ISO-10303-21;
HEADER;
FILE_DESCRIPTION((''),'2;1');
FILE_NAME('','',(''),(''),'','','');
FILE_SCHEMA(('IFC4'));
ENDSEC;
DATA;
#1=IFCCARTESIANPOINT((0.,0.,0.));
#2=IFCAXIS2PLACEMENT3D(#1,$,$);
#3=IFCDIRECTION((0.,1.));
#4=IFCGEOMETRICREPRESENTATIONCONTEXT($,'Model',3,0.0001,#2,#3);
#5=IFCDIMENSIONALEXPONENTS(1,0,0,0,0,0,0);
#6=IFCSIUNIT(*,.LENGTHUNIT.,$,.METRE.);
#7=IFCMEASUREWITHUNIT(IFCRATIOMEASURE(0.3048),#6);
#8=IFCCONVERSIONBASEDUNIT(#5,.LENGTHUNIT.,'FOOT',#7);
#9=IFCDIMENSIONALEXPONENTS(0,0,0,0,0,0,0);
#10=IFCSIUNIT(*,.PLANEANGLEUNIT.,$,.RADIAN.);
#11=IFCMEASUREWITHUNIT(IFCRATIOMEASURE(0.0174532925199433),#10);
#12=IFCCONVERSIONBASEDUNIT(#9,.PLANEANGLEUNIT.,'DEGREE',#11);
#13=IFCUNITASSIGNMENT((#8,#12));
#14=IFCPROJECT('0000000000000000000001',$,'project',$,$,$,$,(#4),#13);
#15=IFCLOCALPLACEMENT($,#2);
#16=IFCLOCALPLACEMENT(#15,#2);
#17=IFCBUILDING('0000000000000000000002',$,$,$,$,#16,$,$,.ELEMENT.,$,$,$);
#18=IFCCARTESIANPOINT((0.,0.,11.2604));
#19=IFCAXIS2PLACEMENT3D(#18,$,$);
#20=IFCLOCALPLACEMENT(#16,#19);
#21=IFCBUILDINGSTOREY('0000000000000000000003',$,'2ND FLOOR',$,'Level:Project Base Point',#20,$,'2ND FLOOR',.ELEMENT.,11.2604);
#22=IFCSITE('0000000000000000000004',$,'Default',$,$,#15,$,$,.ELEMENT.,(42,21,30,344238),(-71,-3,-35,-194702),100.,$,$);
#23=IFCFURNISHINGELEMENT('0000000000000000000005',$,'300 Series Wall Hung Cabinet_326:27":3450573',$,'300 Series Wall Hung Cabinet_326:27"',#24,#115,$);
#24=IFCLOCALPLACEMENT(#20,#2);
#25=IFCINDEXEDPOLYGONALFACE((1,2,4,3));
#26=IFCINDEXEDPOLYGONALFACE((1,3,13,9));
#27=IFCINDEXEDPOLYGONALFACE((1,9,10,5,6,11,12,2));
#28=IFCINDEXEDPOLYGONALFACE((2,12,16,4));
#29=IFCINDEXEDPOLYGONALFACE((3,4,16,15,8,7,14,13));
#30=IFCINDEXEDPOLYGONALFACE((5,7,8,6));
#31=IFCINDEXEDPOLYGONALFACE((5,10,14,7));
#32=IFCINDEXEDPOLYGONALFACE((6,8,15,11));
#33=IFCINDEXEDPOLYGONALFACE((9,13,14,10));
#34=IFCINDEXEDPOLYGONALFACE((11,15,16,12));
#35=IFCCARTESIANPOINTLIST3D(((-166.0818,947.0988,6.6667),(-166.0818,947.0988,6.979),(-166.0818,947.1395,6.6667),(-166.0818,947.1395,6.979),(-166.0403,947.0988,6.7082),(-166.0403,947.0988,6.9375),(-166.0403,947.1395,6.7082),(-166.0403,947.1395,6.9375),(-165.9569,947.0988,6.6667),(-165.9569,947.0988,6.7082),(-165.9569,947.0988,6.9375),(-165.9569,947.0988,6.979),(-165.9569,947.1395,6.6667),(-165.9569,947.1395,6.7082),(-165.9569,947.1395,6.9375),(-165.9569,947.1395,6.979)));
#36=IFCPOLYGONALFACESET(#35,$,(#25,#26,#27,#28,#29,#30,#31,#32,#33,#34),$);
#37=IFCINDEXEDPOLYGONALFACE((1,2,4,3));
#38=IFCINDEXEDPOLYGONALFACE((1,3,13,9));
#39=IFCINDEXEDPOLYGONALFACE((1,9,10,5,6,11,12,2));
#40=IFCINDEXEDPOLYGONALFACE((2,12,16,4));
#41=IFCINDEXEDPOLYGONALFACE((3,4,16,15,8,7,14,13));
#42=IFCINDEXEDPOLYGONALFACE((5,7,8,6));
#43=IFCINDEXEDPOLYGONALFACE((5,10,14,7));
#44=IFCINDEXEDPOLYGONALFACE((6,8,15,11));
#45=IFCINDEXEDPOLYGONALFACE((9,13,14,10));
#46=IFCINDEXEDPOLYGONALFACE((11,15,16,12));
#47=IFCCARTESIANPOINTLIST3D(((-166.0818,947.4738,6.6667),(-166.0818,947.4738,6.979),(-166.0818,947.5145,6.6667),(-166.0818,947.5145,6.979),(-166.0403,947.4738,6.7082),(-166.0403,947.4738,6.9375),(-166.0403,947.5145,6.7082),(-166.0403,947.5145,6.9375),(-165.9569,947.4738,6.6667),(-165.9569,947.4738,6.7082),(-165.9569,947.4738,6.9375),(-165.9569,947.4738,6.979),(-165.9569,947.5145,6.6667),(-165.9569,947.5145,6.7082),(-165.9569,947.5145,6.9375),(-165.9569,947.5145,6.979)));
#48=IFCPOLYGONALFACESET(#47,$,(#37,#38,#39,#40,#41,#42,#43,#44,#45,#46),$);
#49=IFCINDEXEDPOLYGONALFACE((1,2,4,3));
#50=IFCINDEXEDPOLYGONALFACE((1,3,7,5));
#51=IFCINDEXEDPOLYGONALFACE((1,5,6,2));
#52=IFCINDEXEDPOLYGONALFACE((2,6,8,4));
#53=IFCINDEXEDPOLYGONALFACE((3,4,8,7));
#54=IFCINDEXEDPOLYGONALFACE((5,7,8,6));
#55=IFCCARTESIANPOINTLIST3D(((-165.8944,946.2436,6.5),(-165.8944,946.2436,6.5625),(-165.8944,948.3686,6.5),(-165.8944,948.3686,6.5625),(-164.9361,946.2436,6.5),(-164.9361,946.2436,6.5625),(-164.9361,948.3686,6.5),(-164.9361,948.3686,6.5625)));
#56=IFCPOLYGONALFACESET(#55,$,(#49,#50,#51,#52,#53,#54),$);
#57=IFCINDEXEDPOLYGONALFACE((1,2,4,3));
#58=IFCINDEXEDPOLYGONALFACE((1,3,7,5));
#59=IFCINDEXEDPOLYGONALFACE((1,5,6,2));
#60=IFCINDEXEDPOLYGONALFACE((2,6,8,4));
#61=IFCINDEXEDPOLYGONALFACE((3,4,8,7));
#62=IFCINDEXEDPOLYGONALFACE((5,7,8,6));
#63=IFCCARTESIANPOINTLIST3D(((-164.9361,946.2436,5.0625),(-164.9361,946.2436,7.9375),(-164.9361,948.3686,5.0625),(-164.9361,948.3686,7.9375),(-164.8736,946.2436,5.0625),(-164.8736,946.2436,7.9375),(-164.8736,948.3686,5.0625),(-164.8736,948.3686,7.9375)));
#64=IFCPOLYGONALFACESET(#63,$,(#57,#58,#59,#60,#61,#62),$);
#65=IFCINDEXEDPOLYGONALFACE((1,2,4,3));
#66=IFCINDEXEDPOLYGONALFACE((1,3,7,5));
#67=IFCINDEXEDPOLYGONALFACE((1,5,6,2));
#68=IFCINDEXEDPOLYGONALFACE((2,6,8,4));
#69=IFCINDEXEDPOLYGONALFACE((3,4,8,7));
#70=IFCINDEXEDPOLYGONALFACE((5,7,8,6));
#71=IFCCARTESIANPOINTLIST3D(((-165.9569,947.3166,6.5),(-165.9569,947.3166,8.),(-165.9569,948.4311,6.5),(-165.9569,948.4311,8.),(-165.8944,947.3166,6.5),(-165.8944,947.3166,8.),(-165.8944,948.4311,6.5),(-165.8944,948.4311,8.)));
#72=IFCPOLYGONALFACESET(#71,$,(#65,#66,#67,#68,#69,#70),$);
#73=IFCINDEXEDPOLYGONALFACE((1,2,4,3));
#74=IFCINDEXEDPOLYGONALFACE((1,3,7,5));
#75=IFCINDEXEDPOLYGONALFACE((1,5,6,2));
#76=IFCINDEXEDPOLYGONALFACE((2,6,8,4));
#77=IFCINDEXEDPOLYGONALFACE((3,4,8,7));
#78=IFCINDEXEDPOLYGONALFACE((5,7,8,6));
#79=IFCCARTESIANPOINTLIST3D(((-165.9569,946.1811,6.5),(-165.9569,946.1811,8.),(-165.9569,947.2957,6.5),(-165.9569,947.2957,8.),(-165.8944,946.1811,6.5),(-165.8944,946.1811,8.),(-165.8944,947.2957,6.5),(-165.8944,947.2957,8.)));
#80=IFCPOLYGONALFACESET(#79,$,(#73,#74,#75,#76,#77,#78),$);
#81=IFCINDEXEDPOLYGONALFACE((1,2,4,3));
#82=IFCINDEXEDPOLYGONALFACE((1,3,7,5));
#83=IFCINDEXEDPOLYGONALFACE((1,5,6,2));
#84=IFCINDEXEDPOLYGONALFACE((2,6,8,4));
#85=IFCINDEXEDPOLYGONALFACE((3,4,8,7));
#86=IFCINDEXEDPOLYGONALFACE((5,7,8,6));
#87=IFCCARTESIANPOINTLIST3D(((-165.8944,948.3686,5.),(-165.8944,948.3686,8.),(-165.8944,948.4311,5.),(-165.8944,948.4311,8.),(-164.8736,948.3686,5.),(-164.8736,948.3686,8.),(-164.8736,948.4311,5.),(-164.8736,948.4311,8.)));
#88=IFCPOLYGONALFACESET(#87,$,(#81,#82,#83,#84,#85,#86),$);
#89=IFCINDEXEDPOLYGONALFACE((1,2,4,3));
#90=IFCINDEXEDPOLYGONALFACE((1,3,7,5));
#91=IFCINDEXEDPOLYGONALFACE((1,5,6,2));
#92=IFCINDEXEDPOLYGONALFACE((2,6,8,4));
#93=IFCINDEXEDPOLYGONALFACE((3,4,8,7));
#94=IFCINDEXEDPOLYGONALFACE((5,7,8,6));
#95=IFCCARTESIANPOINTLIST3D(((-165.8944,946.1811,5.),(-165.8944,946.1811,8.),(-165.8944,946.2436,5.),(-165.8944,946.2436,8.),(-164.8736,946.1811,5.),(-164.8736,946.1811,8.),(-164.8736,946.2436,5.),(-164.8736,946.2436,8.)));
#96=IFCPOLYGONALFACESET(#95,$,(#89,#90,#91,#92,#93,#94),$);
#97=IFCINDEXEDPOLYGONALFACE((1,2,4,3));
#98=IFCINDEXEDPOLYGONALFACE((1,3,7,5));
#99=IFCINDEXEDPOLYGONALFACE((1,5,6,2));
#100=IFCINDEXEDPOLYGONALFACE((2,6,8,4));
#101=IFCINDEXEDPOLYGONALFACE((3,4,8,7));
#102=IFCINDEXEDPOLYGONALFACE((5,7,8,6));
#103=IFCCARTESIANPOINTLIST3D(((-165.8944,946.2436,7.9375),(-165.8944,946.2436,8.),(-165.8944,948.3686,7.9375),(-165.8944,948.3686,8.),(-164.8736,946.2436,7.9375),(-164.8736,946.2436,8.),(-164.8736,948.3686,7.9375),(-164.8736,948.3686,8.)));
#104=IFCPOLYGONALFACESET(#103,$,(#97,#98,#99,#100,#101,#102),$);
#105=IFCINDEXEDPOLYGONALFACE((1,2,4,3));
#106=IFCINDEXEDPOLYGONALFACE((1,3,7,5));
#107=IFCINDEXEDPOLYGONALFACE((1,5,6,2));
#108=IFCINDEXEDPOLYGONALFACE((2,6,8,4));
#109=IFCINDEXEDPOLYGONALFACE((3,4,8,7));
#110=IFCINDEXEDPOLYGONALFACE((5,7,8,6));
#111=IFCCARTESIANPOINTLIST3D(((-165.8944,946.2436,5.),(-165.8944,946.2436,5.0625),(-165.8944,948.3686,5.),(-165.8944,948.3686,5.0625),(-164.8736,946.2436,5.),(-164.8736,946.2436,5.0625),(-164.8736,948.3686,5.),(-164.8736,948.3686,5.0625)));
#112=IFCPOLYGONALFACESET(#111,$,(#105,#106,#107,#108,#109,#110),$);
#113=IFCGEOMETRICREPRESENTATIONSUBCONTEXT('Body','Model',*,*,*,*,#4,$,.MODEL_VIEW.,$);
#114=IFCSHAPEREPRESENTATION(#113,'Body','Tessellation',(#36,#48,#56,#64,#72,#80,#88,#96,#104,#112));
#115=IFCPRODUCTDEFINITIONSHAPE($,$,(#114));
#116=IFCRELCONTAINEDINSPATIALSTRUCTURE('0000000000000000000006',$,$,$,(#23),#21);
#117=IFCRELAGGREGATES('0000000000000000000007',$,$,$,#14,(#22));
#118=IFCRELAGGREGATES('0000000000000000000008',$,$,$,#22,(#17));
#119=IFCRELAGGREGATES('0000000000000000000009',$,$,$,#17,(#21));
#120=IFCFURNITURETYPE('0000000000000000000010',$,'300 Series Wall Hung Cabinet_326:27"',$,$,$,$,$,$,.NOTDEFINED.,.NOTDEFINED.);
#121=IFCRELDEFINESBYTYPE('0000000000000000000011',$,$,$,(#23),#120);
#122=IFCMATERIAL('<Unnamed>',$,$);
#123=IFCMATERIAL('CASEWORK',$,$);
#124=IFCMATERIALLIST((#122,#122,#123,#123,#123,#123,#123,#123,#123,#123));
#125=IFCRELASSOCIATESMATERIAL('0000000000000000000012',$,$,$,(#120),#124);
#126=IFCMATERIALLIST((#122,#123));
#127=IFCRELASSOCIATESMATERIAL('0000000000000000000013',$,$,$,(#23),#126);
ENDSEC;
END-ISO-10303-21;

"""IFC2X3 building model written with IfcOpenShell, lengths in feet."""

from ifc_helpers import new_model, entity, si_unit, converted_unit, direction, frame, frame_2d, origin, origin_2d_with_axis, place, context, subcontext, project, spatial, polyline, rectangle, outline, extrude, source, transform, mapped, material, material_list, type_object, type_shapes, element, save


model = new_model("IFC2X3")

# Units and contexts
model_context = context("Model", 3, precision=0.0001, world=origin(), true_north=direction((0.0, 1.0)))
body_context = subcontext(model_context, "Body", "Model", "MODEL_VIEW")
ifc_project = project(units=[converted_unit("LENGTHUNIT", "FOOT", entity("IfcRatioMeasure", 0.3048), si_unit("LENGTHUNIT", "METRE"), dimensions=[1, 0, 0, 0, 0, 0, 0]), converted_unit("PLANEANGLEUNIT", "DEGREE", entity("IfcRatioMeasure", 0.0174532925199433), si_unit("PLANEANGLEUNIT", "RADIAN"), dimensions=[0, 0, 0, 0, 0, 0, 0])], contexts=[model_context])

# Site, building, storey
site_placement = place(None, origin())
site = spatial("IfcSite", under=ifc_project, at=site_placement, Name="Default", CompositionType="ELEMENT", RefLatitude=(42, 21, 30, 344238), RefLongitude=(-71, -3, -35, -194702), RefElevation=100.0)
building_placement = place(site_placement, origin())
building = spatial("IfcBuilding", under=site, at=building_placement, CompositionType="ELEMENT")
storey_placement = place(building_placement, frame((0.0, 0.0, 11.2604)))
storey = spatial("IfcBuildingStorey", under=building, at=storey_placement, Name="2ND FLOOR", ObjectType="Level:Project Base Point", LongName="2ND FLOOR", CompositionType="ELEMENT", Elevation=11.2604)

# Furnishing element
ifc_material_1 = material(Name="<Unnamed>")
ifc_material_2 = material(Name="CASEWORK")
ifc_material_list_1 = material_list([ifc_material_1, ifc_material_2])
ifc_material_list_2 = material_list([ifc_material_1, ifc_material_1, ifc_material_2, ifc_material_2, ifc_material_2, ifc_material_2, ifc_material_2, ifc_material_2, ifc_material_2, ifc_material_2])
furniture_type_1 = type_object("IfcFurnitureType", Name="300 Series Wall Hung Cabinet_326:27\"", material=ifc_material_list_2)
shared_shape_1 = source(origin(), body_context, "Body", "SweptSolid", [
    extrude(outline(polyline([(0.1146, -0.0521), (0.1562, -0.0521), (0.1562, 0.0729), (-0.1562, 0.0729), (-0.1562, -0.0521), (-0.1146, -0.0521), (-0.1146, 0.0313), (0.1146, 0.0313), (0.1146, -0.0521)])), frame((1.2917, 0.0729, 1.8229), z_axis=(1.0, 0.0, 0.0), x_axis=(0.0, 0.0, 1.0)), (0.0, 0.0, 1.0), 0.0407),
    extrude(outline(polyline([(0.1146, -0.0521), (0.1562, -0.0521), (0.1562, 0.0729), (-0.1562, 0.0729), (-0.1562, -0.0521), (-0.1146, -0.0521), (-0.1146, 0.0313), (0.1146, 0.0313), (0.1146, -0.0521)])), frame((0.9167, 0.0729, 1.8229), z_axis=(1.0, 0.0, 0.0), x_axis=(0.0, 0.0, 1.0)), (0.0, 0.0, 1.0), 0.0407),
    extrude(rectangle(XDim=0.9583, YDim=2.125, at=origin_2d_with_axis()), frame((1.125, 0.6666, 1.5), z_axis=(0.0, 0.0, 1.0), x_axis=(0.0, 1.0, 0.0)), (0.0, 0.0, 1.0), 0.0625),
    extrude(rectangle(XDim=2.125, YDim=0.0625, at=origin_2d_with_axis()), frame((1.125, 1.177, 0.0625), z_axis=(0.0, 0.0, 1.0), x_axis=(-1.0, 0.0, 0.0)), (0.0, 0.0, 1.0), 2.875),
    extrude(rectangle(XDim=1.1146, YDim=0.0625, at=frame_2d((0.0, 0.0), x_axis=(1.0, 0.0))), frame((0.5573, 0.1562, 1.5), z_axis=(0.0, 0.0, 1.0), x_axis=(-1.0, 0.0, 0.0)), (0.0, 0.0, 1.0), 1.5),
    extrude(rectangle(XDim=1.1146, YDim=0.0625, at=frame_2d((0.0, 0.0), x_axis=(1.0, 0.0))), frame((1.6927, 0.1562, 1.5), z_axis=(0.0, 0.0, 1.0), x_axis=(-1.0, 0.0, 0.0)), (0.0, 0.0, 1.0), 1.5),
    extrude(rectangle(XDim=1.0208, YDim=0.0625, at=frame_2d((0.0, 0.0), x_axis=(1.0, 0.0))), frame((0.0313, 0.6979, 0.0), z_axis=(0.0, 0.0, 1.0), x_axis=(0.0, -1.0, 0.0)), (0.0, 0.0, 1.0), 3.0),
    extrude(rectangle(XDim=1.0208, YDim=0.0625, at=frame_2d((0.0, 0.0), x_axis=(1.0, 0.0))), frame((2.2188, 0.6979, 0.0), z_axis=(0.0, 0.0, 1.0), x_axis=(0.0, -1.0, 0.0)), (0.0, 0.0, 1.0), 3.0),
    extrude(rectangle(XDim=1.0208, YDim=2.125, at=origin_2d_with_axis()), frame((1.125, 0.6979, 2.9375), z_axis=(0.0, 0.0, 1.0), x_axis=(0.0, 1.0, 0.0)), (0.0, 0.0, 1.0), 0.0625),
    extrude(rectangle(XDim=1.0208, YDim=2.125, at=origin_2d_with_axis()), frame((1.125, 0.6979, 0.0), z_axis=(0.0, 0.0, 1.0), x_axis=(0.0, 1.0, 0.0)), (0.0, 0.0, 1.0), 0.0625),
])
type_shapes(furniture_type_1, [shared_shape_1])
furnishing_1_placement = place(storey_placement, frame((-166.0818, 948.4311, 5.0), z_axis=(0.0, 0.0, 1.0), x_axis=(0.0, -1.0, 0.0)))
element("IfcFurnishingElement", 1, at=furnishing_1_placement, inside=storey, type_object=furniture_type_1, material=ifc_material_list_1, Name="300 Series Wall Hung Cabinet_326:27\":3450573", ObjectType="300 Series Wall Hung Cabinet_326:27\"", context=body_context, shape_type="MappedRepresentation", body=[
    mapped(shared_shape_1, transform((0.0, 0.0, 0.0), scale=1.0)),
])

save(model, "model.ifc")
